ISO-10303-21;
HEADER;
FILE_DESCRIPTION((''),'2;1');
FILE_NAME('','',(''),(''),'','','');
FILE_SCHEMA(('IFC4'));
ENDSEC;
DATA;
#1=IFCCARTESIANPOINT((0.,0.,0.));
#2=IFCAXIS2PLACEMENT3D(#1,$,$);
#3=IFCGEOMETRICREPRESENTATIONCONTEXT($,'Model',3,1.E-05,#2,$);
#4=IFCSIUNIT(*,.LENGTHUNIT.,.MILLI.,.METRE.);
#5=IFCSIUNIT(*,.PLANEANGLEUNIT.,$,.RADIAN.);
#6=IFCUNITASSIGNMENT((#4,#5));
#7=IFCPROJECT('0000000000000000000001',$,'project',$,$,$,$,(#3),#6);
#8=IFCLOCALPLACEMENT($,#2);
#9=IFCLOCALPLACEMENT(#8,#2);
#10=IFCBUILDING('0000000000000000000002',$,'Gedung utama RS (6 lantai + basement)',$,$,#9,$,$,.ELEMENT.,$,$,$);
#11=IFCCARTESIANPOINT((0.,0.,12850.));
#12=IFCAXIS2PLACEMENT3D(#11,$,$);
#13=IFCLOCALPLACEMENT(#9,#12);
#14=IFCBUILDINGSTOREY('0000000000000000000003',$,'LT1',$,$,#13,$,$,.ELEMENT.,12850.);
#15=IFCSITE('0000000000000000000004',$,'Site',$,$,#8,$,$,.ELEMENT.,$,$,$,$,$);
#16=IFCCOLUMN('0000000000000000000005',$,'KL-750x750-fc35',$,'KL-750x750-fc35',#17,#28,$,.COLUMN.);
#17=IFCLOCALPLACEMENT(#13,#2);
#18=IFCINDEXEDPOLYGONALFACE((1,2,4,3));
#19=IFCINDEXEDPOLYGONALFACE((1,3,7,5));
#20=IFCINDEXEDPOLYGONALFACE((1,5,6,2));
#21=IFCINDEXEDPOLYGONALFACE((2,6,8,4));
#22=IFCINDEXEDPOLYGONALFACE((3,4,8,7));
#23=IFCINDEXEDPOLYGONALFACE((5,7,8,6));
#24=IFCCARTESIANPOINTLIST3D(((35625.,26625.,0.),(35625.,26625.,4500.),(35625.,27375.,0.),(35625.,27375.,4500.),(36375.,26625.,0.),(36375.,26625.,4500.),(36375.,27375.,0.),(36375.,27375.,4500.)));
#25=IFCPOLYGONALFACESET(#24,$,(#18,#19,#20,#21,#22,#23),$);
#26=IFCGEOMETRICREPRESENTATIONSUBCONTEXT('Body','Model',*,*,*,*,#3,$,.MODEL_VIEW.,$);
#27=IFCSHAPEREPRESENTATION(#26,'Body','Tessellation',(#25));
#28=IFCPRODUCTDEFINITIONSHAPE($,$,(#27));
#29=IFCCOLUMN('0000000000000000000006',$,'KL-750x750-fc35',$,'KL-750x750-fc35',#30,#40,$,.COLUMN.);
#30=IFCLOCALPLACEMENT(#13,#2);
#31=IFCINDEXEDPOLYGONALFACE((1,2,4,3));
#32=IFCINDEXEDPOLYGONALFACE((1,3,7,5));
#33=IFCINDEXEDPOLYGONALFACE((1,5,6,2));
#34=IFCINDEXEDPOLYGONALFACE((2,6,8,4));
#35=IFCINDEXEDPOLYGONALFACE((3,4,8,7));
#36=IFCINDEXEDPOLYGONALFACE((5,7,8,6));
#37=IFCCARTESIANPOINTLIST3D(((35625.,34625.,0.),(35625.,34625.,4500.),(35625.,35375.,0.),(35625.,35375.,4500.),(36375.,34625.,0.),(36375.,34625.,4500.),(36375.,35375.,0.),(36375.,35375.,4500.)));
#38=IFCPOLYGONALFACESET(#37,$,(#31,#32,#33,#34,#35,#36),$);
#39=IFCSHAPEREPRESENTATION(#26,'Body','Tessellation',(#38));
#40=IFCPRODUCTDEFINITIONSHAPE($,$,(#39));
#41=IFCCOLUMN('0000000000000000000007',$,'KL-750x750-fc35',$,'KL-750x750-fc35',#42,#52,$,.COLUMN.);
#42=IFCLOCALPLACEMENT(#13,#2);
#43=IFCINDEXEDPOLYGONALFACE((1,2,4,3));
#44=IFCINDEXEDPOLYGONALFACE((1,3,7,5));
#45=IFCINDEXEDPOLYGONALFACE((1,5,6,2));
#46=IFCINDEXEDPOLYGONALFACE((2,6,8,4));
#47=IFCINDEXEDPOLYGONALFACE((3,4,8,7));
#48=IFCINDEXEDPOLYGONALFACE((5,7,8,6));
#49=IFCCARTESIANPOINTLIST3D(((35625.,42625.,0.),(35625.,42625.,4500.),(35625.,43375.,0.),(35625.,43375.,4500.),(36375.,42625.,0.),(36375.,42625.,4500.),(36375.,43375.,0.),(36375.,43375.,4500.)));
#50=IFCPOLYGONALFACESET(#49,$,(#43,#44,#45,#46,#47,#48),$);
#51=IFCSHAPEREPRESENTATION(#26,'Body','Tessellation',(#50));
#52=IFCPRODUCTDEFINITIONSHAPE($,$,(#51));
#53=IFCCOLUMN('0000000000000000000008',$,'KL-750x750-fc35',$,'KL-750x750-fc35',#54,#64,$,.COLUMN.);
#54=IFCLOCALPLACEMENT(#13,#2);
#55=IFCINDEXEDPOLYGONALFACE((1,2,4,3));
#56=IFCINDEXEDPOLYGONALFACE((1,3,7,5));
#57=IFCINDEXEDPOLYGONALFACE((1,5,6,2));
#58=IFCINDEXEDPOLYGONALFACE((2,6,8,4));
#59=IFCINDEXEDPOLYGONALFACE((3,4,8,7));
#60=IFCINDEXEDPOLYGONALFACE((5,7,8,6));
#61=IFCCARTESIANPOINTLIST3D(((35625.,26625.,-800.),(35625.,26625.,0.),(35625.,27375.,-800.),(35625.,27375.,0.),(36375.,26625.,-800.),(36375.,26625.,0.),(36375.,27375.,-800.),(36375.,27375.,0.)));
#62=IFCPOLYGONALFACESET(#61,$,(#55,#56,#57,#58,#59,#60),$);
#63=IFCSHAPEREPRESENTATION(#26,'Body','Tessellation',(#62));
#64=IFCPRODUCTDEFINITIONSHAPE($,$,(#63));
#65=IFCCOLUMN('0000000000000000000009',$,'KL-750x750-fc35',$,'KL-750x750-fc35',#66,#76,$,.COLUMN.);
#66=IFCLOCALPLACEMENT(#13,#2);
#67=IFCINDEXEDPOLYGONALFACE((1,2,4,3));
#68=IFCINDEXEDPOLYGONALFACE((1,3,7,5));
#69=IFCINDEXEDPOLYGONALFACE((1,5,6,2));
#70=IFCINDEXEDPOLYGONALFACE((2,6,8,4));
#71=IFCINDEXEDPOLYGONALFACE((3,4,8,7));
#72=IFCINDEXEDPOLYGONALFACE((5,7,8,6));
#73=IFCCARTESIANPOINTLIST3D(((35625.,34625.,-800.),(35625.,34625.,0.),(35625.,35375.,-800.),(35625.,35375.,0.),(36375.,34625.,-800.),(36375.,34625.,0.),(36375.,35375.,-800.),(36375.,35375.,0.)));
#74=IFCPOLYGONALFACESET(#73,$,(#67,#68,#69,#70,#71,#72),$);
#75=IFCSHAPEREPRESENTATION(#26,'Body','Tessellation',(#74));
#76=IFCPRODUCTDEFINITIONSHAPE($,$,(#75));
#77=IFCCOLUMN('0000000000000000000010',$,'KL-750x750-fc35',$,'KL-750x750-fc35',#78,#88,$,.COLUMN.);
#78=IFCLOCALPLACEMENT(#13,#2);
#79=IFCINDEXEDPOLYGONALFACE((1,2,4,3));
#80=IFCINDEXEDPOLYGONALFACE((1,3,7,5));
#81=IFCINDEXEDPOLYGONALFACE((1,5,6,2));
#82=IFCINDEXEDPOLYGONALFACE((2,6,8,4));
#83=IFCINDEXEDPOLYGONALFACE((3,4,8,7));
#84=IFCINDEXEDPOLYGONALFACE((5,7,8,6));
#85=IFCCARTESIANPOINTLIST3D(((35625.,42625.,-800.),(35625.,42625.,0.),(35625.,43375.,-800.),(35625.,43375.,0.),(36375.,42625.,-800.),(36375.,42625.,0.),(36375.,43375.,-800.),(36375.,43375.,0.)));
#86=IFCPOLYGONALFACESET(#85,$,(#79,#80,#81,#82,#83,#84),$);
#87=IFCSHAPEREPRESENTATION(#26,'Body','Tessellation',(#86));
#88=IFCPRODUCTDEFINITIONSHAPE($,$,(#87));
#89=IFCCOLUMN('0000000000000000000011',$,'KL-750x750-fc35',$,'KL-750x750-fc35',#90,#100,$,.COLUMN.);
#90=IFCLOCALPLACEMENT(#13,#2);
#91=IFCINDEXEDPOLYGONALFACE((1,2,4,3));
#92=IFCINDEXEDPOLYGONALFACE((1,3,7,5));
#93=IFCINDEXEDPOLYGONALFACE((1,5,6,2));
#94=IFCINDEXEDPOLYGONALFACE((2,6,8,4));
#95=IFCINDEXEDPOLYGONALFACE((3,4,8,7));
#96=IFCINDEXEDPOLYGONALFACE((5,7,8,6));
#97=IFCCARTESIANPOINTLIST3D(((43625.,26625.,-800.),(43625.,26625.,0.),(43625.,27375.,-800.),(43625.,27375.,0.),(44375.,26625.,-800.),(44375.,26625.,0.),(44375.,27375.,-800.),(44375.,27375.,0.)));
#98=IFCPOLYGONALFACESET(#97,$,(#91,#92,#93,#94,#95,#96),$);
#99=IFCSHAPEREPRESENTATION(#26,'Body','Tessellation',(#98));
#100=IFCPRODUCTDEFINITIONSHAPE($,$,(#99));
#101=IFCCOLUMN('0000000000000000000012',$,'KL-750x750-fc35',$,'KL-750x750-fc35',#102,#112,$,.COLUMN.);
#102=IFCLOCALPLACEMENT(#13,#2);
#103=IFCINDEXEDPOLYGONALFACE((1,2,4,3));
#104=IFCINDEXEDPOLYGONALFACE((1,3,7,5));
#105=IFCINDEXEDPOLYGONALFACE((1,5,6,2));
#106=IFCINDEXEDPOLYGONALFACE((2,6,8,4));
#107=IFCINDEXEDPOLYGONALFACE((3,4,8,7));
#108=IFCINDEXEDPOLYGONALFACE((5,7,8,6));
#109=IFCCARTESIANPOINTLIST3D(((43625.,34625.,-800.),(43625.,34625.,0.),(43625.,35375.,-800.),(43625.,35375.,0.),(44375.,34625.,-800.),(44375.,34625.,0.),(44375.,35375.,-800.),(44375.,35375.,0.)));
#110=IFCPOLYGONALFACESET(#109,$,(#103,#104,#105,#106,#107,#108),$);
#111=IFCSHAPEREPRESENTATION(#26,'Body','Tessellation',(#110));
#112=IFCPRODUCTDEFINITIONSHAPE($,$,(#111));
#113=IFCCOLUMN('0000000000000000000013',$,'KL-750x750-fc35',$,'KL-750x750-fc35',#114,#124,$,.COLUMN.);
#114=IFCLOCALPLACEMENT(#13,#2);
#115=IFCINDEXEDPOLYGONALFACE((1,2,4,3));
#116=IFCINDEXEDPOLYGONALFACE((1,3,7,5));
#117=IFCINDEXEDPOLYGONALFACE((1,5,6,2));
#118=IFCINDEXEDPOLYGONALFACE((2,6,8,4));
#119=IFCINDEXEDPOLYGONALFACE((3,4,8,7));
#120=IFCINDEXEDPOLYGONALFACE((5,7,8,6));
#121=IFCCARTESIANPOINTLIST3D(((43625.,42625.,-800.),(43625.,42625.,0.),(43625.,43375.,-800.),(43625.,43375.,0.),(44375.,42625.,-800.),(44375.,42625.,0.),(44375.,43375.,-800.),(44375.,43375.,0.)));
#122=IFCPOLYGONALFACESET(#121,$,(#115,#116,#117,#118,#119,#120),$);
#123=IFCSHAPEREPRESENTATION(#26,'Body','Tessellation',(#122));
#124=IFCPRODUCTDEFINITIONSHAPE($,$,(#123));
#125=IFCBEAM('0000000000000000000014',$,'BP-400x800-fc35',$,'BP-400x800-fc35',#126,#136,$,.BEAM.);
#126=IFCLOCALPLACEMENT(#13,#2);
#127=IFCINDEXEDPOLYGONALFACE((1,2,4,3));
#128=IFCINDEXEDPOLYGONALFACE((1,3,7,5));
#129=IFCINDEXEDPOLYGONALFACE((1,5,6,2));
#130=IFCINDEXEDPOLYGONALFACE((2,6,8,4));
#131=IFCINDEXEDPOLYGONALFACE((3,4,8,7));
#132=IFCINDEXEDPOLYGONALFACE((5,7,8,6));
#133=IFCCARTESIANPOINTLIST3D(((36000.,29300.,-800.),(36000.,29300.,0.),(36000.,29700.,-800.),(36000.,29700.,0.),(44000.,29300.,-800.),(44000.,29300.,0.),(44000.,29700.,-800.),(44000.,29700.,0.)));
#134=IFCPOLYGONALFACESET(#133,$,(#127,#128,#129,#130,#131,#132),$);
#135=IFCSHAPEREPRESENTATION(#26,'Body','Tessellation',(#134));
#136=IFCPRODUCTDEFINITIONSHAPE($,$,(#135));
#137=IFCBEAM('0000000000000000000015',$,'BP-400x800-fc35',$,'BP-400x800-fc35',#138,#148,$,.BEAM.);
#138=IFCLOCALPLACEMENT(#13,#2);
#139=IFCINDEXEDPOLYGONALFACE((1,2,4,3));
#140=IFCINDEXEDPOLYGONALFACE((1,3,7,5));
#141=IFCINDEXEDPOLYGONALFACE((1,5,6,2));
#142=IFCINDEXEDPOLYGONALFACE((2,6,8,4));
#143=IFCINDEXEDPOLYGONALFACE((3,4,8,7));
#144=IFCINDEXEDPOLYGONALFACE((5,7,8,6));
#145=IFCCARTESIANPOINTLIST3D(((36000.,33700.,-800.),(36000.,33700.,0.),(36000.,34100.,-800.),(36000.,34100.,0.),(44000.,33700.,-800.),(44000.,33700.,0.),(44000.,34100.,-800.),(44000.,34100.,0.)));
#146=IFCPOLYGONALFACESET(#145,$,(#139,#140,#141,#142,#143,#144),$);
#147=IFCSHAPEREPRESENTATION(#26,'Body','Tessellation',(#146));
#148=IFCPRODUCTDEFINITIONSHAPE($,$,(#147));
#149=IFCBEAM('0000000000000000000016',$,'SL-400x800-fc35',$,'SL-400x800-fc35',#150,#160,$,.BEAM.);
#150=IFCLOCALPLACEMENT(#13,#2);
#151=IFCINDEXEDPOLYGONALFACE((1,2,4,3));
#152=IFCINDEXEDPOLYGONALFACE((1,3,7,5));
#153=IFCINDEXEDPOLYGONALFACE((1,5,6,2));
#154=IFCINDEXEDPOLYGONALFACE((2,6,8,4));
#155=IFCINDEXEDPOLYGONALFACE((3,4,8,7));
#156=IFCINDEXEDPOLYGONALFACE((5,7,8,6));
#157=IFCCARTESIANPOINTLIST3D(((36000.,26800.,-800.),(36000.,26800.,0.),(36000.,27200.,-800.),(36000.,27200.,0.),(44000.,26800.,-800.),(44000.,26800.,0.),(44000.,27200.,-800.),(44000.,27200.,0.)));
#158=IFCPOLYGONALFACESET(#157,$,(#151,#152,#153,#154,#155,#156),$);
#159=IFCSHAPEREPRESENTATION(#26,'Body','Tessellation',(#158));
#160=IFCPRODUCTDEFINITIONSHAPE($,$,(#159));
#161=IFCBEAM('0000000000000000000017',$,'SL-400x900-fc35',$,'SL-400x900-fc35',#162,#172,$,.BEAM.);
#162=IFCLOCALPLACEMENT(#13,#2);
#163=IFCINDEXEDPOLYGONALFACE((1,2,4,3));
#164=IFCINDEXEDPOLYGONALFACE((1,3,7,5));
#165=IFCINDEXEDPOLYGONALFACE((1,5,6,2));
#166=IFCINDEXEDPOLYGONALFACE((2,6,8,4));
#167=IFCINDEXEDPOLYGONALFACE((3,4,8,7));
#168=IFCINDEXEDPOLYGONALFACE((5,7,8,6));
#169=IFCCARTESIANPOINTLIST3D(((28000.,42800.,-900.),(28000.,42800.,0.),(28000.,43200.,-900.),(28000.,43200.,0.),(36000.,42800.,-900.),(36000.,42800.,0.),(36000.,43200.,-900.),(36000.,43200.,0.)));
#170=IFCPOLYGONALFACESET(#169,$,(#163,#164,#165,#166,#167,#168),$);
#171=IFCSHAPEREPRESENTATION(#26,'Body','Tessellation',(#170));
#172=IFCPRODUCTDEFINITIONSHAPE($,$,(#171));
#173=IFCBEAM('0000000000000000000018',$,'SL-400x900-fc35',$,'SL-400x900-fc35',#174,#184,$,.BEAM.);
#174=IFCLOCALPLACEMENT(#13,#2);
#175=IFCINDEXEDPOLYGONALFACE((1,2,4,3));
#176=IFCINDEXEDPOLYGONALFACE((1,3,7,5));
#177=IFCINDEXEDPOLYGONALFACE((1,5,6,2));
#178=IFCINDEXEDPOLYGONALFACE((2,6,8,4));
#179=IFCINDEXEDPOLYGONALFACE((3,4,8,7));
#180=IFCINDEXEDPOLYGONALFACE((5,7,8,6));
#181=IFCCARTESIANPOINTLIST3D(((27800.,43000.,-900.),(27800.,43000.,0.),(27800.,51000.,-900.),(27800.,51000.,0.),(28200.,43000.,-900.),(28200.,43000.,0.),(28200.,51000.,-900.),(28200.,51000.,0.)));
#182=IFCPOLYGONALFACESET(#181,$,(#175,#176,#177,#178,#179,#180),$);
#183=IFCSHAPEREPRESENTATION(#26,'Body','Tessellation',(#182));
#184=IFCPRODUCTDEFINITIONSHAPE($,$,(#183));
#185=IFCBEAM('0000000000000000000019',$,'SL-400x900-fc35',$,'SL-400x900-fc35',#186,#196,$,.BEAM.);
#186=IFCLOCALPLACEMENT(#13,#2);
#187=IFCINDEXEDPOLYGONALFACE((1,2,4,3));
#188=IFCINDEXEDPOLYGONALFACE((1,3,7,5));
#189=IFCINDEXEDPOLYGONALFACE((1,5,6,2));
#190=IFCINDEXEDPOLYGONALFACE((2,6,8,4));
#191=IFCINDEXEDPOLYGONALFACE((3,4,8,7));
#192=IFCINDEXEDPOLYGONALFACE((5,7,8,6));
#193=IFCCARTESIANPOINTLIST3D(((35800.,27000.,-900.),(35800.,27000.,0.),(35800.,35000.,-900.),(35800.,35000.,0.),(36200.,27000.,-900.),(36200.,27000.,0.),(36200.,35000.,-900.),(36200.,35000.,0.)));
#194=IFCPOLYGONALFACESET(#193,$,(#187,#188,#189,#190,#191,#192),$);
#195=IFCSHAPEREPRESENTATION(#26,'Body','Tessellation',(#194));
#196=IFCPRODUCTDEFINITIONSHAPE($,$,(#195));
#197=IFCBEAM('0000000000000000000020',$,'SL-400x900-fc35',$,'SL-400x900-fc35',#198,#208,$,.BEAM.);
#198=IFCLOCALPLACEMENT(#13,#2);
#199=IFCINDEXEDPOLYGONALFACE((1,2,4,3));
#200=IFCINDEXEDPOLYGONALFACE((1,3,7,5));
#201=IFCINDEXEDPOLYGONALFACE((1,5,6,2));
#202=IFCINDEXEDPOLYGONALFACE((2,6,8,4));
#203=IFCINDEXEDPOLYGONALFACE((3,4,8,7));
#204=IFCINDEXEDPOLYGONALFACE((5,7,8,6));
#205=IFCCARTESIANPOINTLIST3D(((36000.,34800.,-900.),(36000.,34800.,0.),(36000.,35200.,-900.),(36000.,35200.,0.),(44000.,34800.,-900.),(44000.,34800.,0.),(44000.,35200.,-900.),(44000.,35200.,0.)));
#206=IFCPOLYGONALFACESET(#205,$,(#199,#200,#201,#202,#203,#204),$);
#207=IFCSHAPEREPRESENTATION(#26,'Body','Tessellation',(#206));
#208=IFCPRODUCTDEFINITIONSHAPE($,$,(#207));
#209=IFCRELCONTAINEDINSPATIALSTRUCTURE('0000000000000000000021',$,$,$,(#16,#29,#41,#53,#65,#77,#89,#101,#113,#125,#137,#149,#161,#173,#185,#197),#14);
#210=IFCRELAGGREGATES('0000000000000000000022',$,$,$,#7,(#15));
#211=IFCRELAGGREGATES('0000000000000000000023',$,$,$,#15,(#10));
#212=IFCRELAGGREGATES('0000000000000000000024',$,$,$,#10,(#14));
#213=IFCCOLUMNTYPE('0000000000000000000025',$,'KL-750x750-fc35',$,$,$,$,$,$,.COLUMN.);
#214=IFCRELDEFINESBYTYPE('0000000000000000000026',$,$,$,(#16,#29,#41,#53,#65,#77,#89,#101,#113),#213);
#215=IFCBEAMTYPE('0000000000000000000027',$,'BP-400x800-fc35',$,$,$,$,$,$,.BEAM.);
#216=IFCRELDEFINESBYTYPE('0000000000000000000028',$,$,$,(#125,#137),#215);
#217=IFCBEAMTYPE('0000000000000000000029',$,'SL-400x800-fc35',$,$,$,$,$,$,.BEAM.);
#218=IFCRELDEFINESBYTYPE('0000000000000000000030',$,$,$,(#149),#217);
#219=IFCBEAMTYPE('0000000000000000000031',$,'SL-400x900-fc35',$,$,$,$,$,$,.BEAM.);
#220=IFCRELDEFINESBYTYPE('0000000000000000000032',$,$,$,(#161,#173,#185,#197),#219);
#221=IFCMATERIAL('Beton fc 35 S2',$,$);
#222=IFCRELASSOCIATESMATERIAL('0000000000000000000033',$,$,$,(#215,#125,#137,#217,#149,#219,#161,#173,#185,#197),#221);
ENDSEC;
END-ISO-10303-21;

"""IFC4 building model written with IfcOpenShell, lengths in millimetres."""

from ifc_helpers import new_model, si_unit, frame, origin, origin_2d, place, context, subcontext, project, spatial, rectangle, extrude, material, material_profile, profile_set, profile_usage, type_object, element, save


model = new_model("IFC4")

# Units and contexts
model_context = context("Model", 3, precision=1e-05, world=origin())
body_context = subcontext(model_context, "Body", "Model", "MODEL_VIEW")
ifc_project = project(units=[si_unit("LENGTHUNIT", "METRE", prefix="MILLI"), si_unit("PLANEANGLEUNIT", "RADIAN")], contexts=[model_context])

# Site, building, storey
site_placement = place(None, origin())
site = spatial("IfcSite", under=ifc_project, at=site_placement, Name="Site", CompositionType="ELEMENT")
building_placement = place(site_placement, origin())
building = spatial("IfcBuilding", under=site, at=building_placement, Name="Gedung utama RS (6 lantai + basement)", CompositionType="ELEMENT")
storey_placement = place(building_placement, frame((0.0, 0.0, 12850.0)))
storey = spatial("IfcBuildingStorey", under=building, at=storey_placement, Name="LT1", CompositionType="ELEMENT", Elevation=12850.0)

# Columns
ifc_material_profile_1 = material_profile(None, rectangle(XDim=750.0, YDim=750.0, at=origin_2d()), Name="KL-750x750-fc35")
ifc_profile_set_1 = profile_set([ifc_material_profile_1], Name="KL-750x750-fc35")
ifc_profile_usage_1 = profile_usage(ifc_profile_set_1, cardinal=5)
column_type = type_object("IfcColumnType", Name="KL-750x750-fc35", PredefinedType="COLUMN", material=ifc_profile_set_1)
for number, where, z_axis, x_axis, name in (
    (1, (36000.0, 27000.0, 0.0), (0.0, 0.0, 1.0), (1.0, 0.0, 0.0), "KL-750x750-fc35"),
    (2, (36000.0, 35000.0, 0.0), (0.0, 0.0, 1.0), (1.0, 0.0, 0.0), "KL-750x750-fc35"),
    (3, (36000.0, 43000.0, 0.0), (0.0, 0.0, 1.0), (1.0, 0.0, 0.0), "KL-750x750-fc35"),
):
    element("IfcColumn", number, at=place(storey_placement, frame(where, z_axis=z_axis, x_axis=x_axis)), inside=storey, type_object=column_type, material=ifc_profile_usage_1, Name=name, ObjectType="KL-750x750-fc35", PredefinedType="COLUMN", context=body_context, shape_type="SweptSolid", body=[
        extrude(rectangle(XDim=750.0, YDim=750.0, at=origin_2d()), origin(), (0.0, 0.0, 1.0), 4500.0),
    ])
for number, where, z_axis, x_axis, name in (
    (4, (36000.0, 27000.0, -800.0), (0.0, 0.0, 1.0), (1.0, 0.0, 0.0), "KL-750x750-fc35"),
    (5, (36000.0, 35000.0, -800.0), (0.0, 0.0, 1.0), (1.0, 0.0, 0.0), "KL-750x750-fc35"),
    (6, (36000.0, 43000.0, -800.0), (0.0, 0.0, 1.0), (1.0, 0.0, 0.0), "KL-750x750-fc35"),
    (7, (44000.0, 27000.0, -800.0), (0.0, 0.0, 1.0), (1.0, 0.0, 0.0), "KL-750x750-fc35"),
    (8, (44000.0, 35000.0, -800.0), (0.0, 0.0, 1.0), (1.0, 0.0, 0.0), "KL-750x750-fc35"),
    (9, (44000.0, 43000.0, -800.0), (0.0, 0.0, 1.0), (1.0, 0.0, 0.0), "KL-750x750-fc35"),
):
    element("IfcColumn", number, at=place(storey_placement, frame(where, z_axis=z_axis, x_axis=x_axis)), inside=storey, type_object=column_type, material=ifc_profile_usage_1, Name=name, ObjectType="KL-750x750-fc35", PredefinedType="COLUMN", context=body_context, shape_type="SweptSolid", body=[
        extrude(rectangle(XDim=750.0, YDim=750.0, at=origin_2d()), origin(), (0.0, 0.0, 1.0), 800.0),
    ])

# Beams
ifc_material = material(Name="Beton fc 35 S2")
ifc_material_profile_2 = material_profile(ifc_material, rectangle(XDim=400.0, YDim=800.0, at=origin_2d()), Name="BP-400x800-fc35")
ifc_profile_set_2 = profile_set([ifc_material_profile_2], Name="BP-400x800-fc35")
ifc_profile_usage_2 = profile_usage(ifc_profile_set_2, cardinal=8)
beam_type_1 = type_object("IfcBeamType", Name="BP-400x800-fc35", PredefinedType="BEAM", material=ifc_profile_set_2)
for number, where, name in (
    (10, (36000.0, 29500.0, -400.0), "BP-400x800-fc35"),
    (11, (36000.0, 33900.0, -400.0), "BP-400x800-fc35"),
):
    element("IfcBeam", number, at=place(storey_placement, frame(where)), inside=storey, type_object=beam_type_1, material=ifc_profile_usage_2, Name=name, ObjectType="BP-400x800-fc35", PredefinedType="BEAM", context=body_context, shape_type="SweptSolid", body=[
        extrude(rectangle(XDim=400.0, YDim=800.0, at=origin_2d()), frame((0.0, 0.0, 0.0), z_axis=(1.0, 0.0, 0.0), x_axis=(0.0, 1.0, 0.0)), (0.0, 0.0, 1.0), 8000.0),
    ])
ifc_material_profile_3 = material_profile(ifc_material, rectangle(XDim=400.0, YDim=800.0, at=origin_2d()), Name="SL-400x800-fc35")
ifc_profile_set_3 = profile_set([ifc_material_profile_3], Name="SL-400x800-fc35")
ifc_profile_usage_3 = profile_usage(ifc_profile_set_3, cardinal=8)
beam_type_2 = type_object("IfcBeamType", Name="SL-400x800-fc35", PredefinedType="BEAM", material=ifc_profile_set_3)
beam_1_placement = place(storey_placement, frame((36000.0, 27000.0, -400.0)))
element("IfcBeam", 12, at=beam_1_placement, inside=storey, type_object=beam_type_2, material=ifc_profile_usage_3, Name="SL-400x800-fc35", ObjectType="SL-400x800-fc35", PredefinedType="BEAM", context=body_context, shape_type="SweptSolid", body=[
    extrude(rectangle(XDim=400.0, YDim=800.0, at=origin_2d()), frame((0.0, 0.0, 0.0), z_axis=(1.0, 0.0, 0.0), x_axis=(0.0, 1.0, 0.0)), (0.0, 0.0, 1.0), 8000.0),
])
ifc_material_profile_4 = material_profile(ifc_material, rectangle(XDim=400.0, YDim=900.0, at=origin_2d()), Name="SL-400x900-fc35")
ifc_profile_set_4 = profile_set([ifc_material_profile_4], Name="SL-400x900-fc35")
ifc_profile_usage_4 = profile_usage(ifc_profile_set_4, cardinal=8)
beam_type_3 = type_object("IfcBeamType", Name="SL-400x900-fc35", PredefinedType="BEAM", material=ifc_profile_set_4)
beam_2_placement = place(storey_placement, frame((28000.0, 43000.0, -450.0)))
element("IfcBeam", 13, at=beam_2_placement, inside=storey, type_object=beam_type_3, material=ifc_profile_usage_4, Name="SL-400x900-fc35", ObjectType="SL-400x900-fc35", PredefinedType="BEAM", context=body_context, shape_type="SweptSolid", body=[
    extrude(rectangle(XDim=400.0, YDim=900.0, at=origin_2d()), frame((0.0, 0.0, 0.0), z_axis=(1.0, 0.0, 0.0), x_axis=(0.0, 1.0, 0.0)), (0.0, 0.0, 1.0), 8000.0),
])
for number, where, name in (
    (14, (28000.0, 43000.0, -450.0), "SL-400x900-fc35"),
    (15, (36000.0, 27000.0, -450.0), "SL-400x900-fc35"),
):
    element("IfcBeam", number, at=place(storey_placement, frame(where)), inside=storey, type_object=beam_type_3, material=ifc_profile_usage_4, Name=name, ObjectType="SL-400x900-fc35", PredefinedType="BEAM", context=body_context, shape_type="SweptSolid", body=[
        extrude(rectangle(XDim=400.0, YDim=900.0, at=origin_2d()), frame((0.0, 0.0, 0.0), z_axis=(0.0, 1.0, 0.0), x_axis=(-1.0, 0.0, 0.0)), (0.0, 0.0, 1.0), 8000.0),
    ])
beam_3_placement = place(storey_placement, frame((36000.0, 35000.0, -450.0)))
element("IfcBeam", 16, at=beam_3_placement, inside=storey, type_object=beam_type_3, material=ifc_profile_usage_4, Name="SL-400x900-fc35", ObjectType="SL-400x900-fc35", PredefinedType="BEAM", context=body_context, shape_type="SweptSolid", body=[
    extrude(rectangle(XDim=400.0, YDim=900.0, at=origin_2d()), frame((0.0, 0.0, 0.0), z_axis=(1.0, 0.0, 0.0), x_axis=(0.0, 1.0, 0.0)), (0.0, 0.0, 1.0), 8000.0),
])

save(model, "model.ifc")
